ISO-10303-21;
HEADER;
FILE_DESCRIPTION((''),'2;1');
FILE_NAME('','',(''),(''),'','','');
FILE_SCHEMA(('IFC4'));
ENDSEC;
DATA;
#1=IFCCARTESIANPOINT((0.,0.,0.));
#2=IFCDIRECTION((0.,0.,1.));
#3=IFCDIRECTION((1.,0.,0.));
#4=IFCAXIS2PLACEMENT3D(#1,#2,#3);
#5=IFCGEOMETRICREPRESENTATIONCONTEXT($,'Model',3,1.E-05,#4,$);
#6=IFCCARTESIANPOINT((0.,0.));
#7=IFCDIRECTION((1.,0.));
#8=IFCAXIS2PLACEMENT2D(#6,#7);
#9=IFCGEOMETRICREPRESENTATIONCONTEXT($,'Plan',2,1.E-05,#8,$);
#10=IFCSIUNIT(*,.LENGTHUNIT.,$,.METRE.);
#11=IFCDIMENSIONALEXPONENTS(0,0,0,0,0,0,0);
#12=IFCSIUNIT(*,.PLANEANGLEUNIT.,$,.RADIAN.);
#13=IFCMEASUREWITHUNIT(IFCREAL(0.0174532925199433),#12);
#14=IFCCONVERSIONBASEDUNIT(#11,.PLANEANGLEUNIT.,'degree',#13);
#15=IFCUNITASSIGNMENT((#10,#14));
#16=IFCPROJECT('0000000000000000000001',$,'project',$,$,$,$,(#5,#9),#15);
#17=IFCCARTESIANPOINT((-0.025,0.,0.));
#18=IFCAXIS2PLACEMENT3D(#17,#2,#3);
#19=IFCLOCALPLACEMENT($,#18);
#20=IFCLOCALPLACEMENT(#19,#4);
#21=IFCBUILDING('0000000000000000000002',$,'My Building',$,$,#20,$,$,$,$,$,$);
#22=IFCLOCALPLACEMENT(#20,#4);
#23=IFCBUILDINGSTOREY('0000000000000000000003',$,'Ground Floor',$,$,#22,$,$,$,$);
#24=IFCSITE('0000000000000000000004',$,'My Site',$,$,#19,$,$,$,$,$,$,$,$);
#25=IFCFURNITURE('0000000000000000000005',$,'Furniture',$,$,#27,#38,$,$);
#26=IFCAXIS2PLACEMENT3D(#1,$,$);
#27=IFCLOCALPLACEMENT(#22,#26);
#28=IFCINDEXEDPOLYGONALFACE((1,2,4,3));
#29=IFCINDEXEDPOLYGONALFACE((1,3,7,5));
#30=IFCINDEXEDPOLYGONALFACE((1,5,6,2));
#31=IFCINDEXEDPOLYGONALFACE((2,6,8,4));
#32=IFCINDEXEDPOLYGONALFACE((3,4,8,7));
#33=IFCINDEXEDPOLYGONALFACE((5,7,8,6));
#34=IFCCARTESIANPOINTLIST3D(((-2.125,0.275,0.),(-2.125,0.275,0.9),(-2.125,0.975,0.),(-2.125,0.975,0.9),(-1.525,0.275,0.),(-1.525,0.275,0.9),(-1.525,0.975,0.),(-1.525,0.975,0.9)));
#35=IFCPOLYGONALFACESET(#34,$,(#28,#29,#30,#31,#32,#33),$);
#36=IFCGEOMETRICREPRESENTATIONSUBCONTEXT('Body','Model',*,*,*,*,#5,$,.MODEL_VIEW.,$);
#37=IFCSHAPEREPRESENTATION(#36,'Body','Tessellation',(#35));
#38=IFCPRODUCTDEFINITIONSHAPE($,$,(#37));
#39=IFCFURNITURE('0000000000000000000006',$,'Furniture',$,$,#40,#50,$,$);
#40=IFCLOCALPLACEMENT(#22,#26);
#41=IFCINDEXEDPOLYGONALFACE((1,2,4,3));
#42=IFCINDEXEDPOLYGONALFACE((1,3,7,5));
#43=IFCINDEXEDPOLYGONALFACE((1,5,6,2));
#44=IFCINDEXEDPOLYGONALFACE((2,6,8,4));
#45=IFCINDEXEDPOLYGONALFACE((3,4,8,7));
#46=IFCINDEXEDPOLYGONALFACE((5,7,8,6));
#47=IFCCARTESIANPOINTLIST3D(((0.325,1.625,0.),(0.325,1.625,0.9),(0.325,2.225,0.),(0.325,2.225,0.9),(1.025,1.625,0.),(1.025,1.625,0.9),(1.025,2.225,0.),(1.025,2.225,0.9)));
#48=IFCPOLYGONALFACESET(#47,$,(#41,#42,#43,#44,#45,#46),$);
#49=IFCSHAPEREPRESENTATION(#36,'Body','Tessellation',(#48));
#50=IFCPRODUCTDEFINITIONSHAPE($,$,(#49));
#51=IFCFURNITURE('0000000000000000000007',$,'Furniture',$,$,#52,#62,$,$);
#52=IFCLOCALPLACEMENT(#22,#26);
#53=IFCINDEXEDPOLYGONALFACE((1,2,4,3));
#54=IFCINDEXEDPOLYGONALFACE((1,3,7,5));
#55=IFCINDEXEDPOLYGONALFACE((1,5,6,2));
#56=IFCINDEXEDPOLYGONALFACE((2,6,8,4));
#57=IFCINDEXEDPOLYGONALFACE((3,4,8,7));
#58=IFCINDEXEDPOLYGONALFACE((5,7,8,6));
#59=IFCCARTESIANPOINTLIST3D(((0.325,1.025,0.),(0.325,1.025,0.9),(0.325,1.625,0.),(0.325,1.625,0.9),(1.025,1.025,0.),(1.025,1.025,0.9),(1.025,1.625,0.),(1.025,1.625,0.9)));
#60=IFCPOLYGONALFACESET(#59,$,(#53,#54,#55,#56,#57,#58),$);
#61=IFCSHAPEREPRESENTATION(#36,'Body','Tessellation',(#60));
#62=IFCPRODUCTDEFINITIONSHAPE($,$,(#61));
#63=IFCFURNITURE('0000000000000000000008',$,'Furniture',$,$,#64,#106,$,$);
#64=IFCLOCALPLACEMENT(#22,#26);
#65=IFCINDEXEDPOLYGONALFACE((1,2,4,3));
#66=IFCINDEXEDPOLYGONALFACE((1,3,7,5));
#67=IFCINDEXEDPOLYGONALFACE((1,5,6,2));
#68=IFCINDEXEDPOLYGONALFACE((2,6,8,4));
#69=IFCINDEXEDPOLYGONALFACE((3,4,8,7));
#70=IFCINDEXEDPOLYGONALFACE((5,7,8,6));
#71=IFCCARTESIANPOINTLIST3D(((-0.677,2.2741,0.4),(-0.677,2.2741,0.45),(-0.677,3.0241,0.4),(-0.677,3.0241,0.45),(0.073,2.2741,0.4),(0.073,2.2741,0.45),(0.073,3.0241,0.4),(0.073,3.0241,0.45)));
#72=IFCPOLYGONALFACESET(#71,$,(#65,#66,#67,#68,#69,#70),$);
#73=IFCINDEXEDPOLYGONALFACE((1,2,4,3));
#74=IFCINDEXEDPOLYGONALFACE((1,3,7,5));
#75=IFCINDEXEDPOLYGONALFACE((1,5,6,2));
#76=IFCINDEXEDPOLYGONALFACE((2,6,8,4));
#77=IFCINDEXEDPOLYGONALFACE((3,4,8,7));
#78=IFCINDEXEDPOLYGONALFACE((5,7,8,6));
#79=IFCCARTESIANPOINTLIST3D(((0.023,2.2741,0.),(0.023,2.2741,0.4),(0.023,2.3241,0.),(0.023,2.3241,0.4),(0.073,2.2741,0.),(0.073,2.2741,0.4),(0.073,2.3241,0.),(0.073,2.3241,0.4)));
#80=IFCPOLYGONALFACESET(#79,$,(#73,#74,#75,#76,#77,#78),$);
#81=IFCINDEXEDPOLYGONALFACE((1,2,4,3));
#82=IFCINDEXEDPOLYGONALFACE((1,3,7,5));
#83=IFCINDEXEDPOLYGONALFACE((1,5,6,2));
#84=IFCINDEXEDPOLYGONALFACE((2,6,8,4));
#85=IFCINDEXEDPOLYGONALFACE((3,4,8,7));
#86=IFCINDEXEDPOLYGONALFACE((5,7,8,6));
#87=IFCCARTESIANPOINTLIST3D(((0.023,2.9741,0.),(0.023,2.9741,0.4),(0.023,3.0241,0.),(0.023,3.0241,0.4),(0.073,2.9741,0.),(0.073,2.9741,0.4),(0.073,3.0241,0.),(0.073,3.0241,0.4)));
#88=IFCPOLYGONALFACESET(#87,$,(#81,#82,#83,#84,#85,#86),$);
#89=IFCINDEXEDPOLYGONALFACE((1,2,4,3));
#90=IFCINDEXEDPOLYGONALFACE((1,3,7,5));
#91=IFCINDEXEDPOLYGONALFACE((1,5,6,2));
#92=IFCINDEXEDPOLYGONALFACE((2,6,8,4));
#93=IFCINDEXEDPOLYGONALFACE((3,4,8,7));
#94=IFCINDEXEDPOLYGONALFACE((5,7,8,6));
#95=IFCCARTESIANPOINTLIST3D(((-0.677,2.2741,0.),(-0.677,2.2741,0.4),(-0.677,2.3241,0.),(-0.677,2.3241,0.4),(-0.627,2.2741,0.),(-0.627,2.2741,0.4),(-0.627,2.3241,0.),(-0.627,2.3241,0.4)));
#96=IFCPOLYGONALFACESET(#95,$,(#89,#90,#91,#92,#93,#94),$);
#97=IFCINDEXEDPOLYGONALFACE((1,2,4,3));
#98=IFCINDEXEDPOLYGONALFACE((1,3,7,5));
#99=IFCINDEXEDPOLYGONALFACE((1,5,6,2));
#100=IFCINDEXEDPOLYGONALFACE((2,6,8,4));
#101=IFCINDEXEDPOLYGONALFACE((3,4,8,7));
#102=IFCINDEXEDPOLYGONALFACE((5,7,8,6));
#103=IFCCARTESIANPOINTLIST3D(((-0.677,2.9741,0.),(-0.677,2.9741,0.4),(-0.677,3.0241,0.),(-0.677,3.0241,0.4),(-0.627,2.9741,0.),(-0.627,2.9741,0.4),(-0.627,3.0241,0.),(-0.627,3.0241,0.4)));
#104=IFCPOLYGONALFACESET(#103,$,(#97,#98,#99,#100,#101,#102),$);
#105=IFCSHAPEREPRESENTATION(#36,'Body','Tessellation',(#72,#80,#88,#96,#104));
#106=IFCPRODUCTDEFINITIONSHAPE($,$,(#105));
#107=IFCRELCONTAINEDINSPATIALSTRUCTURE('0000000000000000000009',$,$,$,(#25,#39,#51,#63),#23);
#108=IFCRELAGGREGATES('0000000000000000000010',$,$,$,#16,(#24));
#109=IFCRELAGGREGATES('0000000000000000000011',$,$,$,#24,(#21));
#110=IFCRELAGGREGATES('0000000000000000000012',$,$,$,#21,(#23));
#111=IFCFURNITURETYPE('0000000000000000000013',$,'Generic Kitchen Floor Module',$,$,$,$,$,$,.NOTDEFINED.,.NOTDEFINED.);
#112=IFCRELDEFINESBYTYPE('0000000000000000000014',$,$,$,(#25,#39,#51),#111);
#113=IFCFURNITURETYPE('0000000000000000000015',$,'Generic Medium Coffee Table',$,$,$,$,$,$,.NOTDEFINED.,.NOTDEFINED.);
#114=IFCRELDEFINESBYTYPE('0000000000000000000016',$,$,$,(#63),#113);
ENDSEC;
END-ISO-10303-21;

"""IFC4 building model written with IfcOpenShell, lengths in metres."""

from ifc_helpers import new_model, entity, si_unit, converted_unit, frame, origin_with_axes, origin_2d_with_axis, place, context, subcontext, project, spatial, line, indexed_curve, outline, extrude, shape, source, transform, mapped, type_object, type_shapes, element, save


model = new_model("IFC4")

# Units and contexts
model_context = context("Model", 3, precision=1e-05, world=origin_with_axes())
plan_context = context("Plan", 2, precision=1e-05, world=origin_2d_with_axis())
body_context_1 = subcontext(model_context, "Body", "Model", "MODEL_VIEW")
body_context_2 = subcontext(plan_context, "Body", "Plan", "PLAN_VIEW")
ifc_project = project(units=[si_unit("LENGTHUNIT", "METRE"), converted_unit("PLANEANGLEUNIT", "degree", entity("IfcReal", 0.0174532925199433), si_unit("PLANEANGLEUNIT", "RADIAN"), dimensions=[0, 0, 0, 0, 0, 0, 0])], contexts=[model_context, plan_context])

# Site, building, storey
site_placement = place(None, frame((-0.025, 0.0, 0.0), z_axis=(0.0, 0.0, 1.0), x_axis=(1.0, 0.0, 0.0)))
site = spatial("IfcSite", under=ifc_project, at=site_placement, Name="My Site")
building_placement = place(site_placement, origin_with_axes())
building = spatial("IfcBuilding", under=site, at=building_placement, Name="My Building")
storey_placement = place(building_placement, frame((0.0, 0.0, 0.0), z_axis=(0.0, 0.0, 1.0), x_axis=(1.0, 0.0, 0.0)))
storey = spatial("IfcBuildingStorey", under=building, at=storey_placement, Name="Ground Floor")

# Furniture
furniture_type_1 = type_object("IfcFurnitureType", Name="Generic Kitchen Floor Module", AssemblyPlace="NOTDEFINED", PredefinedType="NOTDEFINED")
shared_shape_1 = source(origin_with_axes(), body_context_1, "Body", "SweptSolid", [
    extrude(outline(indexed_curve([(0.0, 0.0), (0.6, 0.0), (0.6, 0.7), (0.0, 0.7)], segments=[line(1, 2, 3, 4, 1)])), origin_with_axes(), (0.0, 0.0, 1.0), 0.9),
])
shared_shape_2 = source(origin_with_axes(), body_context_2, "Body", "Curve2D", [
    entity("IfcIndexedPolyCurve", entity("IfcCartesianPointList2D", [[0.0, 0.0], [0.6, 0.0], [0.6, 0.7], [0.0, 0.7]]), [entity("IfcLineIndex", [1, 2, 3, 4, 1])]),
])
type_shapes(furniture_type_1, [shared_shape_1, shared_shape_2])
for number, where, z_axis, x_axis, name in (
    (1, (-1.525, 0.975, 0.0), (0.0, 0.0, 1.0), (-1.0, 0.0, 0.0), "Furniture"),
    (2, (0.325, 2.225, 0.0), (0.0, 0.0, 1.0), (0.0, -1.0, 0.0), "Furniture"),
    (3, (0.325, 1.625, 0.0), (0.0, 0.0, 1.0), (0.0, -1.0, 0.0), "Furniture"),
):
    element("IfcFurniture", number, at=place(storey_placement, frame(where, z_axis=z_axis, x_axis=x_axis)), inside=storey, type_object=furniture_type_1, Name=name, shapes=[
        shape(body_context_1, "Body", "MappedRepresentation", [mapped(shared_shape_1, transform((0.0, 0.0, 0.0), x_axis=(1.0, 0.0, 0.0), y_axis=(0.0, 1.0, 0.0), z_axis=(0.0, 0.0, 1.0), scale=1.0))]),
        shape(body_context_2, "Body", "MappedRepresentation", [mapped(shared_shape_2, transform((0.0, 0.0, 0.0), x_axis=(1.0, 0.0, 0.0), y_axis=(0.0, 1.0, 0.0), z_axis=(0.0, 0.0, 1.0), scale=1.0))]),
    ])
furniture_type_2 = type_object("IfcFurnitureType", Name="Generic Medium Coffee Table", AssemblyPlace="NOTDEFINED", PredefinedType="NOTDEFINED")
shared_shape_3 = source(origin_with_axes(), body_context_1, "Body", "SweptSolid", [
    extrude(outline(indexed_curve([(0.0, 0.0), (0.75, 0.0), (0.75, 0.75), (0.0, 0.75)], segments=[line(1, 2, 3, 4, 1)])), frame((-0.375, -0.375, 0.4), z_axis=(0.0, 0.0, 1.0), x_axis=(1.0, 0.0, 0.0)), (0.0, 0.0, 1.0), 0.05),
    extrude(outline(indexed_curve([(0.0, 0.0), (0.05, 0.0), (0.05, 0.05), (0.0, 0.05)], segments=[line(1, 2, 3, 4, 1)])), frame((-0.375, -0.375, 0.0), z_axis=(0.0, 0.0, 1.0), x_axis=(1.0, 0.0, 0.0)), (0.0, 0.0, 1.0), 0.4),
    extrude(outline(indexed_curve([(0.75, 0.0), (0.7, 0.0), (0.7, 0.05), (0.75, 0.05)], segments=[line(1, 2, 3, 4, 1)])), frame((-0.375, -0.375, 0.0), z_axis=(0.0, 0.0, 1.0), x_axis=(1.0, 0.0, 0.0)), (0.0, 0.0, 1.0), 0.4),
    extrude(outline(indexed_curve([(0.0, 0.75), (0.05, 0.75), (0.05, 0.7), (0.0, 0.7)], segments=[line(1, 2, 3, 4, 1)])), frame((-0.375, -0.375, 0.0), z_axis=(0.0, 0.0, 1.0), x_axis=(1.0, 0.0, 0.0)), (0.0, 0.0, 1.0), 0.4),
    extrude(outline(indexed_curve([(0.75, 0.75), (0.7, 0.75), (0.7, 0.7), (0.75, 0.7)], segments=[line(1, 2, 3, 4, 1)])), frame((-0.375, -0.375, 0.0), z_axis=(0.0, 0.0, 1.0), x_axis=(1.0, 0.0, 0.0)), (0.0, 0.0, 1.0), 0.4),
])
shared_shape_4 = source(origin_with_axes(), body_context_2, "Body", "Curve2D", [
    entity("IfcIndexedPolyCurve", entity("IfcCartesianPointList2D", [[-0.375, -0.375], [0.375, -0.375], [0.375, 0.375], [-0.375, 0.375]]), [entity("IfcLineIndex", [1, 2, 3, 4, 1])]),
])
type_shapes(furniture_type_2, [shared_shape_3, shared_shape_4])
furniture_1_placement = place(storey_placement, frame((-0.302, 2.6491, 0.0), z_axis=(0.0, 0.0, 1.0), x_axis=(0.0, 1.0, 0.0)))
element("IfcFurniture", 4, at=furniture_1_placement, inside=storey, type_object=furniture_type_2, Name="Furniture", shapes=[
    shape(body_context_1, "Body", "MappedRepresentation", [mapped(shared_shape_3, transform((0.0, 0.0, 0.0), x_axis=(1.0, 0.0, 0.0), y_axis=(0.0, 1.0, 0.0), z_axis=(0.0, 0.0, 1.0), scale=1.0))]),
    shape(body_context_2, "Body", "MappedRepresentation", [mapped(shared_shape_4, transform((0.0, 0.0, 0.0), x_axis=(1.0, 0.0, 0.0), y_axis=(0.0, 1.0, 0.0), z_axis=(0.0, 0.0, 1.0), scale=1.0))]),
])

save(model, "model.ifc")
